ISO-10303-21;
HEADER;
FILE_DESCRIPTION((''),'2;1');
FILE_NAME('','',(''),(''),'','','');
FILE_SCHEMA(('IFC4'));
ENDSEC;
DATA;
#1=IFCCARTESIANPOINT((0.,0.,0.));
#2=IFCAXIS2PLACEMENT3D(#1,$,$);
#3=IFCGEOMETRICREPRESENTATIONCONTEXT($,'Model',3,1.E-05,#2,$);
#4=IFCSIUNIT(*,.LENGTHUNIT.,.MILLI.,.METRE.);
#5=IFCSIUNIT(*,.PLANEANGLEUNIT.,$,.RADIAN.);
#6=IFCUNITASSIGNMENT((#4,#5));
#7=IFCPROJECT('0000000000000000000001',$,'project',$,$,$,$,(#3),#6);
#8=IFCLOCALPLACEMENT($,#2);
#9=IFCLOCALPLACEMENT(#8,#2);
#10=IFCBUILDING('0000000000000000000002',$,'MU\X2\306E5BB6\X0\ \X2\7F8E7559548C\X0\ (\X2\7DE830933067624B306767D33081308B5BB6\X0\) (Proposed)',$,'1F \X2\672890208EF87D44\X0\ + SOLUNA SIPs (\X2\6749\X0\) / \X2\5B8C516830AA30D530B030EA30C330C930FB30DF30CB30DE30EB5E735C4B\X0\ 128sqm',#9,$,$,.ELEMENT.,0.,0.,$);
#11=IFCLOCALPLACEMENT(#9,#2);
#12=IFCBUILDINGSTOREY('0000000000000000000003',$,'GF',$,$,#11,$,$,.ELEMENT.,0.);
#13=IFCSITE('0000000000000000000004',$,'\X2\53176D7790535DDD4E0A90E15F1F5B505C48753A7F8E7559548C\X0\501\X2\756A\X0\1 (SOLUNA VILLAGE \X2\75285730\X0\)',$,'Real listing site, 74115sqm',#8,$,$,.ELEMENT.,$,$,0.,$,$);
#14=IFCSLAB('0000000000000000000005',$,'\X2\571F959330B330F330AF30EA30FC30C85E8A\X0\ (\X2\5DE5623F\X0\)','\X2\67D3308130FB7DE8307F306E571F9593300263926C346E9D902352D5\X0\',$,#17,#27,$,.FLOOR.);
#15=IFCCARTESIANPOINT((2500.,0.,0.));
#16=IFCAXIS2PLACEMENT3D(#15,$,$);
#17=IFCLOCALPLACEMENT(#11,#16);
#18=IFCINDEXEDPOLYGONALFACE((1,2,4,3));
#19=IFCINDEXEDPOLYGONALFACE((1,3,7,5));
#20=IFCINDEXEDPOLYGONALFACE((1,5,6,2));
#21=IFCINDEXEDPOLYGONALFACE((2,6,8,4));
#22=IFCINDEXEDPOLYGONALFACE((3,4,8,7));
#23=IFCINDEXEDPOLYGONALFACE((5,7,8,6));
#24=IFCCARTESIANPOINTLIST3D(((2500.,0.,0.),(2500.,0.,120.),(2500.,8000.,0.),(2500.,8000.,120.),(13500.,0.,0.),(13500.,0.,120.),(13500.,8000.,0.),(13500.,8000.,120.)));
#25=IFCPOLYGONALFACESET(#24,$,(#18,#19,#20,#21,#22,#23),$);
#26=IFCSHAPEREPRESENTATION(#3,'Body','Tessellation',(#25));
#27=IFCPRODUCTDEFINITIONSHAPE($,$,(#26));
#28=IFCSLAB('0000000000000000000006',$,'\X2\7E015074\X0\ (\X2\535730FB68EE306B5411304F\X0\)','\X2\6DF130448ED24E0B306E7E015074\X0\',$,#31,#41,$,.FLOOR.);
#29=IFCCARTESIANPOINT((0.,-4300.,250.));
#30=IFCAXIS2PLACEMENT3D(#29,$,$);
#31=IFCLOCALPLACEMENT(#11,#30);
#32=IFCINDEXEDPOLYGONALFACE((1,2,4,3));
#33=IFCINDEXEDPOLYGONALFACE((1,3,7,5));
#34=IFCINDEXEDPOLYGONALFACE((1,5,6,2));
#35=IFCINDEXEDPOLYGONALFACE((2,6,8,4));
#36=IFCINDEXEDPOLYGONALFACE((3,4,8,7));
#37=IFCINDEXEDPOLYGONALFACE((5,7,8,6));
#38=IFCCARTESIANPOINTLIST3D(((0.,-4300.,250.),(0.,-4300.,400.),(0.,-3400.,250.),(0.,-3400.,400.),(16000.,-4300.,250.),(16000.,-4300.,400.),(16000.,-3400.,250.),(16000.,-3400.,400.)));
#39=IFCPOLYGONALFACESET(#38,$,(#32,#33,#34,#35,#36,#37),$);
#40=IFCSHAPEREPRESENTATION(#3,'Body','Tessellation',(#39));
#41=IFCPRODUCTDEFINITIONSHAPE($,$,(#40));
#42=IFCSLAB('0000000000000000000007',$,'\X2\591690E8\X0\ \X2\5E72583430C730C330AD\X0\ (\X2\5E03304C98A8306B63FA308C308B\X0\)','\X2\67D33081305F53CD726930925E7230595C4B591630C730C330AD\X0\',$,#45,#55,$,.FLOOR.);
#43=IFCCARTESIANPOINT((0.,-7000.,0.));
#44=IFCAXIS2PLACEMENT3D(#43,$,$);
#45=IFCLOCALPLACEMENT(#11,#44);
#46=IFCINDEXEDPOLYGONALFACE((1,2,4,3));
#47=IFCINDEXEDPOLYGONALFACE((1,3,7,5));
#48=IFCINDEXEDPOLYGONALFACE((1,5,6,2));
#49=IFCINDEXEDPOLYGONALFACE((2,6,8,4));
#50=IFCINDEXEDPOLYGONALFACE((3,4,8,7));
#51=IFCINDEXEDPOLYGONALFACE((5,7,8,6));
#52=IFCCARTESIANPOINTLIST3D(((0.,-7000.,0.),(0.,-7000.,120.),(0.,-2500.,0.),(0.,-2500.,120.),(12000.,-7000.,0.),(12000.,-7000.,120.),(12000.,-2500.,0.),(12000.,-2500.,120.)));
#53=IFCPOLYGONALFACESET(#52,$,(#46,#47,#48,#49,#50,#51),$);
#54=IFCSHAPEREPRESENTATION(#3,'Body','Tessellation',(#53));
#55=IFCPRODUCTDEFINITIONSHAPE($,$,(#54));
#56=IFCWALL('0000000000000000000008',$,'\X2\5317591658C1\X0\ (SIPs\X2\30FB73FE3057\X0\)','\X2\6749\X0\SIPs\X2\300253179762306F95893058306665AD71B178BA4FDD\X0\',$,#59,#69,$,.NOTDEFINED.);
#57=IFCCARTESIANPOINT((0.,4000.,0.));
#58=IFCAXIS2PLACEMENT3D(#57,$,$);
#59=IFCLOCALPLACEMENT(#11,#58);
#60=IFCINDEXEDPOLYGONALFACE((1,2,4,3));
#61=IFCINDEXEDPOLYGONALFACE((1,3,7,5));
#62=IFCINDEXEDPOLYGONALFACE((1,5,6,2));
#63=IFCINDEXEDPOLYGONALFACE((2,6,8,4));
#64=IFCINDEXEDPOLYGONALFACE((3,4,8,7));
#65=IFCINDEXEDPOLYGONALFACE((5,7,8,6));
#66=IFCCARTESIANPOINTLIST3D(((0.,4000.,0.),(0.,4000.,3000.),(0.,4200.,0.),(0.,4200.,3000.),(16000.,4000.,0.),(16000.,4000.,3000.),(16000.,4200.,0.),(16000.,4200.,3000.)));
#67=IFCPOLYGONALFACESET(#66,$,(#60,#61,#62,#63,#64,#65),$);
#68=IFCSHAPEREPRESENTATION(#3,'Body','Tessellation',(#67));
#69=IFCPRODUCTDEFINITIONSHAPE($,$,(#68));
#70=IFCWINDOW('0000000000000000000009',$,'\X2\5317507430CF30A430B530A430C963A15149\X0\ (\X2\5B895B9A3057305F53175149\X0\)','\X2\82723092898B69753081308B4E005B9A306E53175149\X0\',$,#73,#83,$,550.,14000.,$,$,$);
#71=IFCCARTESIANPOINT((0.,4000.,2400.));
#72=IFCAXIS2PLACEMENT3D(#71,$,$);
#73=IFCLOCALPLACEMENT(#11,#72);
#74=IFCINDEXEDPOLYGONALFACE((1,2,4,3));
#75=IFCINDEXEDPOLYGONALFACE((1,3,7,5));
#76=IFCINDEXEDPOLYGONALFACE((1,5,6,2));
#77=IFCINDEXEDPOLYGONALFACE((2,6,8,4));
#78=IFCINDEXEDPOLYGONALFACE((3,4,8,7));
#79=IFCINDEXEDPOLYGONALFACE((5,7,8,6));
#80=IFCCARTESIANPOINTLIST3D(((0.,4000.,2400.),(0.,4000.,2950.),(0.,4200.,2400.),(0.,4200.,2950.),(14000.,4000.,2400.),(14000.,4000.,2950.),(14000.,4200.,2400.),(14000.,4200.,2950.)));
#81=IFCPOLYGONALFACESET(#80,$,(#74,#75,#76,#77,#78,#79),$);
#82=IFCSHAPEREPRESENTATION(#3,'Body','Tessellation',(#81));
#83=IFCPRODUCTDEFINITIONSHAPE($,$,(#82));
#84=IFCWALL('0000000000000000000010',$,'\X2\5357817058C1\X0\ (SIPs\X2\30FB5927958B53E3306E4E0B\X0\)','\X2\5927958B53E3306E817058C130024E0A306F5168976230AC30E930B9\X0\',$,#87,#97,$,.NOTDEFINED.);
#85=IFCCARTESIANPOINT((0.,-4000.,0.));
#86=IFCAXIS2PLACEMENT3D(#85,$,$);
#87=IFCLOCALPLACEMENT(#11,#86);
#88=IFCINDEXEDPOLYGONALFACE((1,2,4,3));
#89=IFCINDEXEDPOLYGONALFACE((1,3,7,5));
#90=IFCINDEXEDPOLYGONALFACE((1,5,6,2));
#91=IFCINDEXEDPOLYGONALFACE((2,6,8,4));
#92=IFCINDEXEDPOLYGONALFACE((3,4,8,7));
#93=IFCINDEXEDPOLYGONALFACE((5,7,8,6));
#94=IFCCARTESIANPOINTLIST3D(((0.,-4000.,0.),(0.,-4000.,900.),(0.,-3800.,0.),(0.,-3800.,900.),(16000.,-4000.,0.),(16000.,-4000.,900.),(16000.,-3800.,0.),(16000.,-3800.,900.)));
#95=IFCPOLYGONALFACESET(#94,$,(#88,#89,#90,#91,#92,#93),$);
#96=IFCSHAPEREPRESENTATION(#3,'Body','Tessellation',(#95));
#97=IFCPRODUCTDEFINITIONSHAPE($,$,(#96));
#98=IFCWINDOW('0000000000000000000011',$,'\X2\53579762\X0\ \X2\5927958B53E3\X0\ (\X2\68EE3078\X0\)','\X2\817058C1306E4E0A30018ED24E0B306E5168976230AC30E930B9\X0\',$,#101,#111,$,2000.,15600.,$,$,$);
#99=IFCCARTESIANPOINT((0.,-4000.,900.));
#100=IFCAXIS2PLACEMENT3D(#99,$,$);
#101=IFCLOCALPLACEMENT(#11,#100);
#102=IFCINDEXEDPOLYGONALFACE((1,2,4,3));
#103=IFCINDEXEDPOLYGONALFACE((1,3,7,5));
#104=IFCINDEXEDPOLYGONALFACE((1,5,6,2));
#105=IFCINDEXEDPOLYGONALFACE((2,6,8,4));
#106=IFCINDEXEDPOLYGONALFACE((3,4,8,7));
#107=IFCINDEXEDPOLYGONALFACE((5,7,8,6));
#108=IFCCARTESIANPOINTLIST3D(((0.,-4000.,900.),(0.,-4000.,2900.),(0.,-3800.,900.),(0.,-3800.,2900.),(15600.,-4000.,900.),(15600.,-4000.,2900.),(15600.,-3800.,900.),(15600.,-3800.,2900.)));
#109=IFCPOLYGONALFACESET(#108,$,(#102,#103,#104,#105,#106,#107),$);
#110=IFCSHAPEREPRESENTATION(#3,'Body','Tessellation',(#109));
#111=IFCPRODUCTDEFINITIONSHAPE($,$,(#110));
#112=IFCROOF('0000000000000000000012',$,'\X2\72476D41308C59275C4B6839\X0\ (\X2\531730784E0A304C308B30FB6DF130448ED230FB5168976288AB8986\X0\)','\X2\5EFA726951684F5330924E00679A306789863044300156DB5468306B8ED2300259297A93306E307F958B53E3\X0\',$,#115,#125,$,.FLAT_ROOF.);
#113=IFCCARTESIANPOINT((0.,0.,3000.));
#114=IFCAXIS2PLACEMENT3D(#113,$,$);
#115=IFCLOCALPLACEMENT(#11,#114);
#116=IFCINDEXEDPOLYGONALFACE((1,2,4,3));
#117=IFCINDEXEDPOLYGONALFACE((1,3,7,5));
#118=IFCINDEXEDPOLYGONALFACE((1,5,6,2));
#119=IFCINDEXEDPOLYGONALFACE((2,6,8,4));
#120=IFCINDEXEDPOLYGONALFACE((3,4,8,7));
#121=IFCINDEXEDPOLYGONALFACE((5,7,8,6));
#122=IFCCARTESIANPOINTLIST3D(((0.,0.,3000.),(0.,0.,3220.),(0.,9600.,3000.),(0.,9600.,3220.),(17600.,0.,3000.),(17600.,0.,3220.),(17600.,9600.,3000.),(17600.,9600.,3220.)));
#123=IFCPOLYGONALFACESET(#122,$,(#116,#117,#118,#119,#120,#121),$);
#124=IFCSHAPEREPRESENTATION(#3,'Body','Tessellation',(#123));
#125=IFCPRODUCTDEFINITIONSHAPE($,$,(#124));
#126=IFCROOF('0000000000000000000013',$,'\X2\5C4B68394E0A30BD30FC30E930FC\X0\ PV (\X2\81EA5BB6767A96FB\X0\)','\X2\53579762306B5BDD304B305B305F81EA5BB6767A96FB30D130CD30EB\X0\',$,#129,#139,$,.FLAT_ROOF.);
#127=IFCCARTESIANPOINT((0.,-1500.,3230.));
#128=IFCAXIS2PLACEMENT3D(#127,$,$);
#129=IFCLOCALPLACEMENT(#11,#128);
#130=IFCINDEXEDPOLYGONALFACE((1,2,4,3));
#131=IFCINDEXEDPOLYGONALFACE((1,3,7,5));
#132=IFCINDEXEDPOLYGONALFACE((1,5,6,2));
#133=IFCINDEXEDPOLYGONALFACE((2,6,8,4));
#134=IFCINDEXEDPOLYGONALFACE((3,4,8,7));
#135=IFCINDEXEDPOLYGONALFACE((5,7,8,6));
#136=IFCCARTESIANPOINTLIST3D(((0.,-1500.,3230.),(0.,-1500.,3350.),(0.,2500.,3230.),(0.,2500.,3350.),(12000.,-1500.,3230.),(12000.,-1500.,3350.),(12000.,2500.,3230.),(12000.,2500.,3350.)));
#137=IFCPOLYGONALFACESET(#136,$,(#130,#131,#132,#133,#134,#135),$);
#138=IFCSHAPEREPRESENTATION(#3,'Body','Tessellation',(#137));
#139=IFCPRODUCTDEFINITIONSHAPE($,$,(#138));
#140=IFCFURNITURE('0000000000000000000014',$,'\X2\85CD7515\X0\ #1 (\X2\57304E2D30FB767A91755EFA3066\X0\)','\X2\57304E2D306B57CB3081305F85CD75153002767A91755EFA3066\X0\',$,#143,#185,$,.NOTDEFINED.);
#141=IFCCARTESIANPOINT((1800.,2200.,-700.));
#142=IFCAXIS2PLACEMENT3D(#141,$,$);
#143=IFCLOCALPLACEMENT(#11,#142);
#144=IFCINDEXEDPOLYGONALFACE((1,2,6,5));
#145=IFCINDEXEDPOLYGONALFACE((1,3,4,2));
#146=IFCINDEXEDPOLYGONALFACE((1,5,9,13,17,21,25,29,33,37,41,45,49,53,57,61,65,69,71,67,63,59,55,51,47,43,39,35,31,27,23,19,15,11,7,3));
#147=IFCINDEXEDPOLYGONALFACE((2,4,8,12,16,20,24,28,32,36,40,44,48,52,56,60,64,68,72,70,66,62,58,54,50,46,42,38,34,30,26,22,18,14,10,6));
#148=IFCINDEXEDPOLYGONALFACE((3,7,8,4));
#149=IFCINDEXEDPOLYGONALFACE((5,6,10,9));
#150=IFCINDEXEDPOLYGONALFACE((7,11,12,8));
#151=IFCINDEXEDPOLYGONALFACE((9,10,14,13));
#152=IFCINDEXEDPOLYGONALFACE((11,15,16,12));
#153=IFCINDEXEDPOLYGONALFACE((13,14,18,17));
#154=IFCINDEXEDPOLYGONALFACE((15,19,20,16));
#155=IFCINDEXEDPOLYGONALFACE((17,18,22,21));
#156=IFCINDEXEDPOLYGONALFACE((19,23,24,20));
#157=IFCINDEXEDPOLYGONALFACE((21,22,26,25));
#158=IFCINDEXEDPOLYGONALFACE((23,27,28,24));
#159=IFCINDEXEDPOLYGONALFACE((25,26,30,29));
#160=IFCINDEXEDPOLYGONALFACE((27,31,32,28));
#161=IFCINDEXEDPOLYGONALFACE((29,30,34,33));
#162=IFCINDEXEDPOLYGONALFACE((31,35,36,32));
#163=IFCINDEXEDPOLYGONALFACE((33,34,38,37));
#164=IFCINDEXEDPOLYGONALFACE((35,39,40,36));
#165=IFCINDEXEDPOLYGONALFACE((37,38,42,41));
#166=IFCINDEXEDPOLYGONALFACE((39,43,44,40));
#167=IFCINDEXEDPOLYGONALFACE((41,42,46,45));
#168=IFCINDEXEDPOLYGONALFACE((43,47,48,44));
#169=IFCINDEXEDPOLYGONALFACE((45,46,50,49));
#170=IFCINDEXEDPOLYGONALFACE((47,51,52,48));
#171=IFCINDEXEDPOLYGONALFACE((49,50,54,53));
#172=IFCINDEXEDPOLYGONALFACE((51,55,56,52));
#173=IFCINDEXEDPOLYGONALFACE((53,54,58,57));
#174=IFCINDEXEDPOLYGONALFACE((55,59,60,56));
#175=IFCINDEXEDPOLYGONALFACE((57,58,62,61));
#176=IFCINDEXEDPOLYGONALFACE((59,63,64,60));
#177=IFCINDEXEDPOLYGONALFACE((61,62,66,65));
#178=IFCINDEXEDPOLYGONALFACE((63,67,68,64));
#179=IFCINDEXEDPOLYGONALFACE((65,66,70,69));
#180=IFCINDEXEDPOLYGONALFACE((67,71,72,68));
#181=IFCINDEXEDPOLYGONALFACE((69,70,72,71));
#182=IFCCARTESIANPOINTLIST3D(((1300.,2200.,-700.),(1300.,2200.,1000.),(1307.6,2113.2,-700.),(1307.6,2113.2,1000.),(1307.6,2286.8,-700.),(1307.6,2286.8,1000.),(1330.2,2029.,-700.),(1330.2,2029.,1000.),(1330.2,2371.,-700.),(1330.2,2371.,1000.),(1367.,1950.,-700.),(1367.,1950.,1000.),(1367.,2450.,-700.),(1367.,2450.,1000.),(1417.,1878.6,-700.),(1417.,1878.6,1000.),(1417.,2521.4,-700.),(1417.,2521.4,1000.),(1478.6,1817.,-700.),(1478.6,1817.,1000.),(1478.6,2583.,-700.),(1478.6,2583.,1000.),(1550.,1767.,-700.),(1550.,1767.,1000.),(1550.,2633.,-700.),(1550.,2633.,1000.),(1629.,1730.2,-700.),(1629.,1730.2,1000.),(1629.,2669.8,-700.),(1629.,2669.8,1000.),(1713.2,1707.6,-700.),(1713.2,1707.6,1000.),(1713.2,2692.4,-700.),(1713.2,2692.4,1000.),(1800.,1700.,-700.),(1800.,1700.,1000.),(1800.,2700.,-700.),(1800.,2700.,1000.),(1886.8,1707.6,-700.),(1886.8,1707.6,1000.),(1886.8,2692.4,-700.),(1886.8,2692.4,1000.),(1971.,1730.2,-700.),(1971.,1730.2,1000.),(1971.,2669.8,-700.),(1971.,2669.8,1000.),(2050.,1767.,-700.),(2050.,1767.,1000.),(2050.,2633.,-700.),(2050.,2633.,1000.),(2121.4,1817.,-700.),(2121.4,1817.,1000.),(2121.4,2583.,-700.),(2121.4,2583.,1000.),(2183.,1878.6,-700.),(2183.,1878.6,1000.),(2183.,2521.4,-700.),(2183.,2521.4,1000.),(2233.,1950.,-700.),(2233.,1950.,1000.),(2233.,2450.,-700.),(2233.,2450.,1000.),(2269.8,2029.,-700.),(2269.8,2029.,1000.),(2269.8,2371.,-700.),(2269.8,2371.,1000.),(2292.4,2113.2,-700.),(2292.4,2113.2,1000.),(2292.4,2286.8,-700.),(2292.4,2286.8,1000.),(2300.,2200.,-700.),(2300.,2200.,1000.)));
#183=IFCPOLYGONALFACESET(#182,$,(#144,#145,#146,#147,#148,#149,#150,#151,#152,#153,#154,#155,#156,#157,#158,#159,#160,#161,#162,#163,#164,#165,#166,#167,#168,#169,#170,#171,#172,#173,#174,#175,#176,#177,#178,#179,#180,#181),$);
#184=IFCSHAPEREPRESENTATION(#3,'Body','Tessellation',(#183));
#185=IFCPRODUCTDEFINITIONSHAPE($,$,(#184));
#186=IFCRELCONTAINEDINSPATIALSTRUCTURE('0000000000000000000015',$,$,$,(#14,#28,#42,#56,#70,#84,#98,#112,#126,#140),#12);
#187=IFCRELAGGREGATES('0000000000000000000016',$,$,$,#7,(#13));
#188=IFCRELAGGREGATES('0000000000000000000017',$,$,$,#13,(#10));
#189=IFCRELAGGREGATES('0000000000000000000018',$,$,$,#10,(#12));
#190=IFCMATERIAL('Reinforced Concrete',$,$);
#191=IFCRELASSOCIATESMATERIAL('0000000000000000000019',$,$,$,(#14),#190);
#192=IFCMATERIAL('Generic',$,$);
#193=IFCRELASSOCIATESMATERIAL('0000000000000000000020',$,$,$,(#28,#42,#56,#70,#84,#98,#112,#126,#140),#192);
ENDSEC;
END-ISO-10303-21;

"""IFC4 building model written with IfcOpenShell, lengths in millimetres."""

from ifc_helpers import new_model, si_unit, frame, frame_2d, origin, origin_2d, place, context, project, spatial, rectangle, circle, extrude, material, element, fill, save


model = new_model("IFC4")

# Units and contexts
model_context = context("Model", 3, precision=1e-05, world=origin())
ifc_project = project(units=[si_unit("LENGTHUNIT", "METRE", prefix="MILLI"), si_unit("PLANEANGLEUNIT", "RADIAN")], contexts=[model_context])

# Site, building, storey
site_placement = place(None, origin())
site = spatial("IfcSite", under=ifc_project, at=site_placement, Name="北海道川上郡弟子屈町美留和501番1 (SOLUNA VILLAGE 用地)", ObjectType="Real listing site, 74115sqm", CompositionType="ELEMENT", RefElevation=0.0)
building_placement = place(site_placement, origin())
building = spatial("IfcBuilding", under=site, at=building_placement, Name="MUの家 美留和 (編んで手で染める家) (Proposed)", ObjectType="1F 木造軸組 + SOLUNA SIPs (杉) / 完全オフグリッド・ミニマル平屋 128sqm", CompositionType="ELEMENT", ElevationOfRefHeight=0.0, ElevationOfTerrain=0.0)
storey_placement = place(building_placement, origin())
storey = spatial("IfcBuildingStorey", under=building, at=storey_placement, Name="GF", CompositionType="ELEMENT", Elevation=0.0)

# Slabs
ifc_material_1 = material(Name="Generic")
ifc_material_2 = material(Name="Reinforced Concrete")
slab_1_placement = place(storey_placement, frame((2500.0, 0.0, 0.0)))
element("IfcSlab", 1, at=slab_1_placement, inside=storey, material=ifc_material_2, Name="土間コンクリート床 (工房)", Description="染め・編みの土間。排水溝連動", PredefinedType="FLOOR", context=model_context, shape_type="SweptSolid", body=[
    extrude(rectangle(XDim=11000.0, YDim=8000.0, at=frame_2d((5500.0, 4000.0))), frame((2500.0, 0.0, 0.0)), (0.0, 0.0, 1.0), 120.0),
])
slab_2_placement = place(storey_placement, frame((0.0, -4300.0, 250.0)))
element("IfcSlab", 2, at=slab_2_placement, inside=storey, material=ifc_material_1, Name="縁側 (南・森に向く)", Description="深い軒下の縁側", PredefinedType="FLOOR", context=model_context, shape_type="SweptSolid", body=[
    extrude(rectangle(XDim=16000.0, YDim=900.0, at=frame_2d((8000.0, 450.0))), frame((0.0, -4300.0, 250.0)), (0.0, 0.0, 1.0), 150.0),
])
slab_3_placement = place(storey_placement, frame((0.0, -7000.0, 0.0)))
element("IfcSlab", 3, at=slab_3_placement, inside=storey, material=ifc_material_1, Name="外部 干場デッキ (布が風に揺れる)", Description="染めた反物を干す屋外デッキ", PredefinedType="FLOOR", context=model_context, shape_type="SweptSolid", body=[
    extrude(rectangle(XDim=12000.0, YDim=4500.0, at=frame_2d((6000.0, 2250.0))), frame((0.0, -7000.0, 0.0)), (0.0, 0.0, 1.0), 120.0),
])

# Wall, opening, window
wall_1_placement = place(storey_placement, frame((0.0, 4000.0, 0.0)))
wall_1 = element("IfcWall", 4, at=wall_1_placement, inside=storey, material=ifc_material_1, Name="北外壁 (SIPs・現し)", Description="杉SIPs。北面は閉じて断熱確保", PredefinedType="NOTDEFINED", context=model_context, shape_type="SweptSolid", body=[
    extrude(rectangle(XDim=16000.0, YDim=200.0, at=frame_2d((8000.0, 100.0))), frame((0.0, 4000.0, 0.0)), (0.0, 0.0, 1.0), 3000.0),
])
opening_placement = place(storey_placement, frame((0.0, 4000.0, 2400.0)))
opening = element("IfcOpeningElement", 5, at=opening_placement, cuts=wall_1, PredefinedType="NOTDEFINED", context=model_context, shape_type="SweptSolid", body=[
    extrude(rectangle(XDim=14000.0, YDim=200.0, at=frame_2d((7000.0, 100.0))), frame((0.0, 4000.0, 2400.0)), (0.0, 0.0, 1.0), 550.0),
])
window_1_placement = place(storey_placement, frame((0.0, 4000.0, 2400.0)))
window_1 = element("IfcWindow", 6, at=window_1_placement, inside=storey, material=ifc_material_1, Name="北側ハイサイド採光 (安定した北光)", Description="色を見極める一定の北光", OverallHeight=550.0, OverallWidth=14000.0, context=model_context, shape_type="SweptSolid", body=[
    extrude(rectangle(XDim=14000.0, YDim=200.0, at=frame_2d((7000.0, 100.0))), frame((0.0, 4000.0, 2400.0)), (0.0, 0.0, 1.0), 550.0),
])
fill(opening, window_1)

# Wall
wall_2_placement = place(storey_placement, frame((0.0, -4000.0, 0.0)))
element("IfcWall", 7, at=wall_2_placement, inside=storey, material=ifc_material_1, Name="南腰壁 (SIPs・大開口の下)", Description="大開口の腰壁。上は全面ガラス", PredefinedType="NOTDEFINED", context=model_context, shape_type="SweptSolid", body=[
    extrude(rectangle(XDim=16000.0, YDim=200.0, at=frame_2d((8000.0, 100.0))), frame((0.0, -4000.0, 0.0)), (0.0, 0.0, 1.0), 900.0),
])

# Window
window_2_placement = place(storey_placement, frame((0.0, -4000.0, 900.0)))
element("IfcWindow", 8, at=window_2_placement, inside=storey, material=ifc_material_1, Name="南面 大開口 (森へ)", Description="腰壁の上、軒下の全面ガラス", OverallHeight=2000.0, OverallWidth=15600.0, context=model_context, shape_type="SweptSolid", body=[
    extrude(rectangle(XDim=15600.0, YDim=200.0, at=frame_2d((7800.0, 100.0))), frame((0.0, -4000.0, 900.0)), (0.0, 0.0, 1.0), 2000.0),
])

# Roofs
roof_1_placement = place(storey_placement, frame((0.0, 0.0, 3000.0)))
element("IfcRoof", 9, at=roof_1_placement, inside=storey, material=ifc_material_1, Name="片流れ大屋根 (北へ上がる・深い軒・全面被覆)", Description="建物全体を一枚で覆い、四周に軒。天窓のみ開口", PredefinedType="FLAT_ROOF", context=model_context, shape_type="SweptSolid", body=[
    extrude(rectangle(XDim=17600.0, YDim=9600.0, at=frame_2d((8800.0, 4800.0))), frame((0.0, 0.0, 3000.0)), (0.0, 0.0, 1.0), 220.0),
])
roof_2_placement = place(storey_placement, frame((0.0, -1500.0, 3230.0)))
element("IfcRoof", 10, at=roof_2_placement, inside=storey, material=ifc_material_1, Name="屋根上ソーラー PV (自家発電)", Description="南面に寝かせた自家発電パネル", PredefinedType="FLAT_ROOF", context=model_context, shape_type="SweptSolid", body=[
    extrude(rectangle(XDim=12000.0, YDim=4000.0, at=frame_2d((6000.0, 2000.0))), frame((0.0, -1500.0, 3230.0)), (0.0, 0.0, 1.0), 120.0),
])

# Furniture
furniture_1_placement = place(storey_placement, frame((1800.0, 2200.0, -700.0)))
element("IfcFurniture", 11, at=furniture_1_placement, inside=storey, material=ifc_material_1, Name="藍甕 #1 (地中・発酵建て)", Description="地中に埋めた藍甕。発酵建て", PredefinedType="NOTDEFINED", context=model_context, shape_type="SweptSolid", body=[
    extrude(circle(Radius=500.0, at=origin_2d()), frame((1800.0, 2200.0, -700.0)), (0.0, 0.0, 1.0), 1700.0),
])

save(model, "model.ifc")
